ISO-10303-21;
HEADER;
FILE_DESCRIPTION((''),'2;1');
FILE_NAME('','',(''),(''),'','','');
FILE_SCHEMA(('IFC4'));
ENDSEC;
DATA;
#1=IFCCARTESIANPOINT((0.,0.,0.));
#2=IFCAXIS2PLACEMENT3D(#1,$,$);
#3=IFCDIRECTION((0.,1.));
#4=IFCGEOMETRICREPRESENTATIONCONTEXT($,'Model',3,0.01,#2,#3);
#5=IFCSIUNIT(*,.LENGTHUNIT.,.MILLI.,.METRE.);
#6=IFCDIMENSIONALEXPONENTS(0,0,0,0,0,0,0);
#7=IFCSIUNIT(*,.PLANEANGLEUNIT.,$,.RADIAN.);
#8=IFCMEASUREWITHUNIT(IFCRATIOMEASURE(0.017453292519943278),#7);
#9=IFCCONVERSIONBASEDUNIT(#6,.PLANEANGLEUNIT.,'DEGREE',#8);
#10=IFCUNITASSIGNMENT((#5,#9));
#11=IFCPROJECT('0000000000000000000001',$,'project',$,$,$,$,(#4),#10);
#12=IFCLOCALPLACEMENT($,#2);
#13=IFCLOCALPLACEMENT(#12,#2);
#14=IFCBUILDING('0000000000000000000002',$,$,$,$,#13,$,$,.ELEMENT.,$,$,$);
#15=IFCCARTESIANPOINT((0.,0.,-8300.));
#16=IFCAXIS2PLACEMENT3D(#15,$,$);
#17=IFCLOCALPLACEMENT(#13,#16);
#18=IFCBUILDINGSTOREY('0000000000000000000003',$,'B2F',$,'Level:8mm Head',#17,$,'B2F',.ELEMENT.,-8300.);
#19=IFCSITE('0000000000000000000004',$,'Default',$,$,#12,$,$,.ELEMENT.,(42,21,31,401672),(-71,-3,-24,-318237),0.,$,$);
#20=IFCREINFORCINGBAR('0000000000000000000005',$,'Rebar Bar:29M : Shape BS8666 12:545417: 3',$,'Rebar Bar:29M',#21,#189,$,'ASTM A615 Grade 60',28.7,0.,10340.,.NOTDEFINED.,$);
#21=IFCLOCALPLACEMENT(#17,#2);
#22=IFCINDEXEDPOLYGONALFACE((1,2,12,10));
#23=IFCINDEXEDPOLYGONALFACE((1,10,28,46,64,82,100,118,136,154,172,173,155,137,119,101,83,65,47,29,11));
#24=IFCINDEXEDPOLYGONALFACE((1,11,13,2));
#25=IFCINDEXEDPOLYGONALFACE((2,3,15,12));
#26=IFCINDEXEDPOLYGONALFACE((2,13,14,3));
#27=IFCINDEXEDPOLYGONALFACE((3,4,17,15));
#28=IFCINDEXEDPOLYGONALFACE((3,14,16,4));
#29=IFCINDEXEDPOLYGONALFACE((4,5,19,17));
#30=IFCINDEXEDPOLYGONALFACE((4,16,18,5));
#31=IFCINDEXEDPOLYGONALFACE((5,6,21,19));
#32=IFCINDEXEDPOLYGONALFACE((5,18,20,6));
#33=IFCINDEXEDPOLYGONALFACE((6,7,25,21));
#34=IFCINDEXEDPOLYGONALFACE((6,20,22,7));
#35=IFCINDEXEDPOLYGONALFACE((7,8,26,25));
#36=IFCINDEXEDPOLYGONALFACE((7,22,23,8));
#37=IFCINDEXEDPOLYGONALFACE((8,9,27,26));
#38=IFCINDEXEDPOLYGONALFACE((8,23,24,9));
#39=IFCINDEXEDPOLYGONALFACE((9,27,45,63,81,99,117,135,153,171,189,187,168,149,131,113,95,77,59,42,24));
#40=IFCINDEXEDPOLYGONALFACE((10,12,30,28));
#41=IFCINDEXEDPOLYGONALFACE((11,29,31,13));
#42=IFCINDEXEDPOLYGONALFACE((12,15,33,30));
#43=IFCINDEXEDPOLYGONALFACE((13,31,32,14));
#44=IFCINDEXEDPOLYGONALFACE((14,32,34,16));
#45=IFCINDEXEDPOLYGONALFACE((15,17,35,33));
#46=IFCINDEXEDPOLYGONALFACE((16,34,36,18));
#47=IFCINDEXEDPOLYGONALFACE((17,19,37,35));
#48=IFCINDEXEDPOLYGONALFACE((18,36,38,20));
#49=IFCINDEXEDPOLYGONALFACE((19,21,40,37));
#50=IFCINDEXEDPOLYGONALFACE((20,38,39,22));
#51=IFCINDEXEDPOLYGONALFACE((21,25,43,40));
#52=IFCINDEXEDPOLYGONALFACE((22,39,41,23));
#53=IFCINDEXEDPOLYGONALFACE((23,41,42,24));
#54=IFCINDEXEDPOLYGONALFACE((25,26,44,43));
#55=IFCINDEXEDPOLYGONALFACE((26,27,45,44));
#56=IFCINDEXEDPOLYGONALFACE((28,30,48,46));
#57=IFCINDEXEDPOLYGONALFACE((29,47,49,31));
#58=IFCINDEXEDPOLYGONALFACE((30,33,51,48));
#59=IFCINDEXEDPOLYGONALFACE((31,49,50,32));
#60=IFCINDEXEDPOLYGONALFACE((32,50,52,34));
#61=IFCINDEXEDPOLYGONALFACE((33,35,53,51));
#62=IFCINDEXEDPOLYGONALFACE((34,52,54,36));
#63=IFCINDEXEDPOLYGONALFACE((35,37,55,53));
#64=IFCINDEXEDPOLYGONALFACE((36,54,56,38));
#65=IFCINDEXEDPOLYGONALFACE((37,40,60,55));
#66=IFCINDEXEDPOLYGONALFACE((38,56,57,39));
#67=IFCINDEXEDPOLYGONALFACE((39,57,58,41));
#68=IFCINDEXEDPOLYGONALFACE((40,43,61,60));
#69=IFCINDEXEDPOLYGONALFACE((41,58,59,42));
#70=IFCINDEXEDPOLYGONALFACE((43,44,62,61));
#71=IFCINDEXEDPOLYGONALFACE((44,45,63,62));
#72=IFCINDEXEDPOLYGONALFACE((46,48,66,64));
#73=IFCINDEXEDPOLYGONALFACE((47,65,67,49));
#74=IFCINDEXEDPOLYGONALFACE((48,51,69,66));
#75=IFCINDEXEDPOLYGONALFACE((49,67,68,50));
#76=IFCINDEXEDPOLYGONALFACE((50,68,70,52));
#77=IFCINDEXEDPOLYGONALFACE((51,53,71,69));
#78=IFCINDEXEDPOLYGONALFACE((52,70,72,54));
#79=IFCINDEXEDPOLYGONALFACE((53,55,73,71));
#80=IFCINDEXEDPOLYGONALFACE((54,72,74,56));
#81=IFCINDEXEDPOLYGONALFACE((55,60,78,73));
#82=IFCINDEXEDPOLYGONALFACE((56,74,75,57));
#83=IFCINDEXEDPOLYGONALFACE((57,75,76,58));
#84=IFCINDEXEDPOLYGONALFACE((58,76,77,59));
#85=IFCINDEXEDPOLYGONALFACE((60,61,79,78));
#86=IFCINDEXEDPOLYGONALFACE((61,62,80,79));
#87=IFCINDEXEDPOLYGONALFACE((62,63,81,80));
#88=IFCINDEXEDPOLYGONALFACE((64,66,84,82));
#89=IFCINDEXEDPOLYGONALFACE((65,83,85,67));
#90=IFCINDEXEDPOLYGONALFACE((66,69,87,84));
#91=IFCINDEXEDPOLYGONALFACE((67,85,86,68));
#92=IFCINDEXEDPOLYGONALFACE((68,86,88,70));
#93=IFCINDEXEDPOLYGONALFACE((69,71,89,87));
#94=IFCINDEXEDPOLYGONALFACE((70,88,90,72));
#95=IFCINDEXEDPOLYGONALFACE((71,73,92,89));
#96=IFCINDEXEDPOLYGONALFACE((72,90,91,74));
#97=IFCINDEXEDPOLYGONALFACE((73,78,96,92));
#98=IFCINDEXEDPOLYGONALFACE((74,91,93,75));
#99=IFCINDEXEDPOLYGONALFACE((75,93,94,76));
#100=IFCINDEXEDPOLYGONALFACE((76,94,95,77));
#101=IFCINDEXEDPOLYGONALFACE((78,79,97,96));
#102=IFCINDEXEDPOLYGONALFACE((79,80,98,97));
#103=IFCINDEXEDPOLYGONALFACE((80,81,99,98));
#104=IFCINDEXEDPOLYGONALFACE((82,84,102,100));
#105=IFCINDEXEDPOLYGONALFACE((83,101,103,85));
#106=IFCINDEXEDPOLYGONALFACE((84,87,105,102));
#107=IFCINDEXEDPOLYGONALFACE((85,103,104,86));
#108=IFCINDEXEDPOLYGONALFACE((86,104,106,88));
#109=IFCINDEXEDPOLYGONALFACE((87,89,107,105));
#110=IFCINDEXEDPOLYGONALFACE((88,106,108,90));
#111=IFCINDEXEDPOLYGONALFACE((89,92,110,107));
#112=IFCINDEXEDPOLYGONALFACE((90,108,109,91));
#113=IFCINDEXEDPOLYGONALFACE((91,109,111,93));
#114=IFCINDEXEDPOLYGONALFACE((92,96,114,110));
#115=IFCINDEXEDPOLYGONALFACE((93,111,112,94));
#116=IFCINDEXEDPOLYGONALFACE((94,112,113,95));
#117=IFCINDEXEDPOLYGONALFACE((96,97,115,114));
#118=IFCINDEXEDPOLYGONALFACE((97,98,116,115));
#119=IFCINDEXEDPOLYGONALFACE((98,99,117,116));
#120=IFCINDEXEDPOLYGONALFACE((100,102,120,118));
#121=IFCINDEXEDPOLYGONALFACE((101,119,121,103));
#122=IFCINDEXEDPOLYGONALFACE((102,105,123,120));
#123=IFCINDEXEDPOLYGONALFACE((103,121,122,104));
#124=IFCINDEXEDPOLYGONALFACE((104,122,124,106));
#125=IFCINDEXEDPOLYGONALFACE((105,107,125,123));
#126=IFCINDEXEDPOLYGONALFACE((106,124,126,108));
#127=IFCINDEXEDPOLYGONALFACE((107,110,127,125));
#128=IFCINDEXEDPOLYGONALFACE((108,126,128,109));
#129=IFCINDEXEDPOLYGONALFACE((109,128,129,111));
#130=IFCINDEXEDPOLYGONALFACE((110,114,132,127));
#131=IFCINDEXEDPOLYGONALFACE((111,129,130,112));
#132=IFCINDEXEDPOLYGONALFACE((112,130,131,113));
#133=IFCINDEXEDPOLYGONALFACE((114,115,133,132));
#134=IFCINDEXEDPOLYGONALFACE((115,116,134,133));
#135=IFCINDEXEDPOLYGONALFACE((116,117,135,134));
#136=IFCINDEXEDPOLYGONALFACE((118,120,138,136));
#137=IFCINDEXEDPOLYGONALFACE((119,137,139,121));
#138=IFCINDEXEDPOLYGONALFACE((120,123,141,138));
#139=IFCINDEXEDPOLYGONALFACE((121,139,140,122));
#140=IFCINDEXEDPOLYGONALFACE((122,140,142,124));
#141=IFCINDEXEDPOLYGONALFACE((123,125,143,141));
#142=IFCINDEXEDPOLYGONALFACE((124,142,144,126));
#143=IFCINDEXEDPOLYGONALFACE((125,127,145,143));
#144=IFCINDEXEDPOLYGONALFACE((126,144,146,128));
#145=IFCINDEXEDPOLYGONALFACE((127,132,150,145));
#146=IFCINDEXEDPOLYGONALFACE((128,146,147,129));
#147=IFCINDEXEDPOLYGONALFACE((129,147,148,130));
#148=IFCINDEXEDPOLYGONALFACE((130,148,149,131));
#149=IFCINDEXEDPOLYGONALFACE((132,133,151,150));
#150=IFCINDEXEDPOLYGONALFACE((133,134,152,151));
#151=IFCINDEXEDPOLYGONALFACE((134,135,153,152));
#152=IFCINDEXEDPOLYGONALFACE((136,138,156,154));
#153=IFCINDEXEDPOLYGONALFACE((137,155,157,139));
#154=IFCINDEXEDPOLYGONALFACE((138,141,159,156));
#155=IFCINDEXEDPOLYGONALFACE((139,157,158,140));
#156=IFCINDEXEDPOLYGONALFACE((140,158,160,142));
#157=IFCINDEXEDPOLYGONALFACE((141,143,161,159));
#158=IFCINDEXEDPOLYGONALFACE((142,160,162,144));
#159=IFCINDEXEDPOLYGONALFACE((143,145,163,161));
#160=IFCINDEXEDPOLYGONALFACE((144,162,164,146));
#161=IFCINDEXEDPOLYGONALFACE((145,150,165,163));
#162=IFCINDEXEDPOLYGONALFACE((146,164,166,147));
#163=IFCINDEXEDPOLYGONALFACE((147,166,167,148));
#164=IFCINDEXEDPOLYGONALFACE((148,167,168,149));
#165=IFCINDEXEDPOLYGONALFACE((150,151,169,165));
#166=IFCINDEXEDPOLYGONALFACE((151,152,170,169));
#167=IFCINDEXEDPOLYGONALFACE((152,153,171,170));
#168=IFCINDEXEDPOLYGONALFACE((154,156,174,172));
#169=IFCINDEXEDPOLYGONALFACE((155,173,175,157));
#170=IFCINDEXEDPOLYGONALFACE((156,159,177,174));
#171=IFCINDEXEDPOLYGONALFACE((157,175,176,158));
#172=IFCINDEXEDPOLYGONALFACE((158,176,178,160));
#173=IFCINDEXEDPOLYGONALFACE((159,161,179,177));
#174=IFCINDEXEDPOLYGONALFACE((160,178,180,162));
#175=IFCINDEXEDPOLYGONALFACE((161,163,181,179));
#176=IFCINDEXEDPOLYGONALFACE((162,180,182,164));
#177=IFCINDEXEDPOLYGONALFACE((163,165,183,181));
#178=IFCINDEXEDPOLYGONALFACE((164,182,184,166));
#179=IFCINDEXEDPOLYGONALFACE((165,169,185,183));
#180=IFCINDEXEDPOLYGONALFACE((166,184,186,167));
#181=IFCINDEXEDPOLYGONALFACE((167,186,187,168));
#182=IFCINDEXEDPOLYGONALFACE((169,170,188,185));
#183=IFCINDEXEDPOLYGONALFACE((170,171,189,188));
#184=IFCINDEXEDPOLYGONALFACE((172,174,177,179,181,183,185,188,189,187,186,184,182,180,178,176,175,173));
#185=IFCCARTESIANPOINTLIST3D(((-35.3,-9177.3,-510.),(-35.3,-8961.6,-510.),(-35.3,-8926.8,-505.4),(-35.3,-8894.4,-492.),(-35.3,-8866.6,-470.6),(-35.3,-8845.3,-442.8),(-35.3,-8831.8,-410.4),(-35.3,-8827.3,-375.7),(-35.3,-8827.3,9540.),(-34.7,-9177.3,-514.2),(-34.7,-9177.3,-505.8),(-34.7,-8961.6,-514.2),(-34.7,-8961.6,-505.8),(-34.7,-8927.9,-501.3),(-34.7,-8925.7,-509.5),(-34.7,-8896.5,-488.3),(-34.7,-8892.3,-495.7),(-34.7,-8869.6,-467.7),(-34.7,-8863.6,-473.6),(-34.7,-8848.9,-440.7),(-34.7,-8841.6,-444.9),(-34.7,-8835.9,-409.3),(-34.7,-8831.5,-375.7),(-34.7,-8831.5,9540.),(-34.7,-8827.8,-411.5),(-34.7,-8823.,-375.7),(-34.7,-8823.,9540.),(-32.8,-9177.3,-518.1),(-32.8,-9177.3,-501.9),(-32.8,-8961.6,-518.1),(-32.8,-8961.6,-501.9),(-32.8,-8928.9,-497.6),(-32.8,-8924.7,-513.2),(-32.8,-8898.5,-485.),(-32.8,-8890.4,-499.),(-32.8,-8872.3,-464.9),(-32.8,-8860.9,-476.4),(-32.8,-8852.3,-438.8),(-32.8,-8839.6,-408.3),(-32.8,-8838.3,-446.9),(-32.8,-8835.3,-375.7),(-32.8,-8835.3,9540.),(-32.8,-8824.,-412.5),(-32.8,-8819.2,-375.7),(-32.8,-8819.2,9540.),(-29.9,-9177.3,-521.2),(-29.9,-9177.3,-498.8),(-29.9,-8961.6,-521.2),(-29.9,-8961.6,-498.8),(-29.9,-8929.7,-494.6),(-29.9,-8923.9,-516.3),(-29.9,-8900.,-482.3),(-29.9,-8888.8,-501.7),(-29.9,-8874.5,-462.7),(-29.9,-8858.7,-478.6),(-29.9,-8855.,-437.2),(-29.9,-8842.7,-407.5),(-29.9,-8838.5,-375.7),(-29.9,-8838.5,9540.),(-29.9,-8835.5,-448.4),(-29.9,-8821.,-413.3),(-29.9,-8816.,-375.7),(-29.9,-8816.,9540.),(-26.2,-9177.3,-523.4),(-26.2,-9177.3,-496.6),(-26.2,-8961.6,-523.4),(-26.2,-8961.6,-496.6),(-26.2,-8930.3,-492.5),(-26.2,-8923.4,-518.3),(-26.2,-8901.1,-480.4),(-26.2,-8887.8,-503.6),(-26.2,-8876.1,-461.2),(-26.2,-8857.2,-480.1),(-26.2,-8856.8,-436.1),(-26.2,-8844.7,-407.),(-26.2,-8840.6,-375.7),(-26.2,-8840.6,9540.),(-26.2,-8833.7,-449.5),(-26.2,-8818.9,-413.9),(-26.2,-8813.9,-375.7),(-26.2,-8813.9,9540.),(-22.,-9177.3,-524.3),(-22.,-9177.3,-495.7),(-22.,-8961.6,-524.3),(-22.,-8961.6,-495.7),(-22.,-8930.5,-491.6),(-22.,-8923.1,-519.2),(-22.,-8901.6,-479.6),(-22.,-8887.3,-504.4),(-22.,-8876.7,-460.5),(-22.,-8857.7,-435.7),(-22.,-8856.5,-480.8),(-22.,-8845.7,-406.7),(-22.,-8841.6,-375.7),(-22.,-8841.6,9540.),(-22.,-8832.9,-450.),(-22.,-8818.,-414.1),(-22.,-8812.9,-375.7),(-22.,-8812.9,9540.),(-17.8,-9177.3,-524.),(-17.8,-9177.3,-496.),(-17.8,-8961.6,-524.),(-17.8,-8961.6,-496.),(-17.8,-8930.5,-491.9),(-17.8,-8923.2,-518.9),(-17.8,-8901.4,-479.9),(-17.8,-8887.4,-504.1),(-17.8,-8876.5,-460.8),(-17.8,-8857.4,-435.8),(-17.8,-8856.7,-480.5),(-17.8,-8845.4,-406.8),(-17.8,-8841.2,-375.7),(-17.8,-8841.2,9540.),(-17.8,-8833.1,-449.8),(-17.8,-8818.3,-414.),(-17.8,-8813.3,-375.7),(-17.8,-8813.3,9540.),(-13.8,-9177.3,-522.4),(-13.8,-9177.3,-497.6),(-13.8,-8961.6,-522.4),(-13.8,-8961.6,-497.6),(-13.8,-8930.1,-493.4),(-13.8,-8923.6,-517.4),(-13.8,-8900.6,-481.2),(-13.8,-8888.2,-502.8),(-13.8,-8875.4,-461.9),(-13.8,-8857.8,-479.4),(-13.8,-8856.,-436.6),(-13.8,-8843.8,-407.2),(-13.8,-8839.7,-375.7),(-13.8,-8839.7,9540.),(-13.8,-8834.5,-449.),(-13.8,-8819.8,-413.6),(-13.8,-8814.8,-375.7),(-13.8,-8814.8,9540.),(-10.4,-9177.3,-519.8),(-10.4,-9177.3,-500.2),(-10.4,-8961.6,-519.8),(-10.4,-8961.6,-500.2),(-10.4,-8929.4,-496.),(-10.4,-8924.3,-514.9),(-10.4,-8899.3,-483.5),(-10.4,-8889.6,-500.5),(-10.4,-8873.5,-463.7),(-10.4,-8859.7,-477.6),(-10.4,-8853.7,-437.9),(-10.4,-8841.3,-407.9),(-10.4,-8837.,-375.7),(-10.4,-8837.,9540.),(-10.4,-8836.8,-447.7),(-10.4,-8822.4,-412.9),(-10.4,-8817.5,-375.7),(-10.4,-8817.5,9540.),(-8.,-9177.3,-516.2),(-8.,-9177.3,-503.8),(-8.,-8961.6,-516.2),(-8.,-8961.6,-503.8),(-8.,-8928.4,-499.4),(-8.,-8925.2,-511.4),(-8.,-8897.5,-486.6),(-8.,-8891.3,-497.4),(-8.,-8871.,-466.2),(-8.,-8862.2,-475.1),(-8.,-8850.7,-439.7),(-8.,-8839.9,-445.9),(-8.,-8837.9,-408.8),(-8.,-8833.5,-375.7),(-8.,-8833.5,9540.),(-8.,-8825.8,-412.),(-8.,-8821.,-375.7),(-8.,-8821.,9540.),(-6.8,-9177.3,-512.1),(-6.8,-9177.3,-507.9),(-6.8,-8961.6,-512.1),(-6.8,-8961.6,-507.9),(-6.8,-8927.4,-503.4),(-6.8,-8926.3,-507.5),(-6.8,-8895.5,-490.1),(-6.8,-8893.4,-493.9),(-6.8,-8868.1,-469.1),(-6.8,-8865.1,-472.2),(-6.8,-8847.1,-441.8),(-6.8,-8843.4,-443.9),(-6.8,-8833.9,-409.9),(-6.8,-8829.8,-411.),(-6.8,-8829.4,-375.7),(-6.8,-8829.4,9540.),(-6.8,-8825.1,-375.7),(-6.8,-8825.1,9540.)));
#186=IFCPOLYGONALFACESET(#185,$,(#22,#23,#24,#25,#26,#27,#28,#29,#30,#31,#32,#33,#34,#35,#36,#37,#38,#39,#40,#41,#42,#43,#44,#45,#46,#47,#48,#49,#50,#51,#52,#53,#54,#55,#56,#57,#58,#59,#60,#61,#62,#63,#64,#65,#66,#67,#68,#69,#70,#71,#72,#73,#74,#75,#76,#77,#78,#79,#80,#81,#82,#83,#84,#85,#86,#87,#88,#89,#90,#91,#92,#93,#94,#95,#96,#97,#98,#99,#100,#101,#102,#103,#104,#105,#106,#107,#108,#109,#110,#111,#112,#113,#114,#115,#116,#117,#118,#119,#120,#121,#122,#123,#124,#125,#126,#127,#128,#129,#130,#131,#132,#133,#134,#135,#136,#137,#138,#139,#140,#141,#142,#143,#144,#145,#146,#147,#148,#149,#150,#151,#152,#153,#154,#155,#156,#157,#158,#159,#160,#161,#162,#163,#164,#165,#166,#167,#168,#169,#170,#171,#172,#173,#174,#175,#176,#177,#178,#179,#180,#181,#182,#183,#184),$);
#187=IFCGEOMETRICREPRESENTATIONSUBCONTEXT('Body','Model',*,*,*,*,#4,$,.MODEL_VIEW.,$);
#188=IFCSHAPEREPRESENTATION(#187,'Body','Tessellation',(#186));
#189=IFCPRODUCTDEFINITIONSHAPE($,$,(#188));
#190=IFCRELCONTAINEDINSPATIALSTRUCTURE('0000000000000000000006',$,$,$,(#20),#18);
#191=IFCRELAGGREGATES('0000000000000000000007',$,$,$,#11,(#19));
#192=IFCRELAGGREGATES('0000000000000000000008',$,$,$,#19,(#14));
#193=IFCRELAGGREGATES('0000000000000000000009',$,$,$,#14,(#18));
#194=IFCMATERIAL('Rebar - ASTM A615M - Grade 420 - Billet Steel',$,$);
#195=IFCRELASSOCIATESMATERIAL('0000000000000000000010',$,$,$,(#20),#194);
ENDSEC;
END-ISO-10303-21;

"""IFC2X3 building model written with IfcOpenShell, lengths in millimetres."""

from ifc_helpers import new_model, entity, si_unit, converted_unit, direction, frame, origin, place, context, subcontext, project, spatial, material, element, save


model = new_model("IFC2X3")

# Units and contexts
model_context = context("Model", 3, precision=0.01, world=origin(), true_north=direction((0.0, 1.0)))
body_context = subcontext(model_context, "Body", "Model", "MODEL_VIEW")
ifc_project = project(units=[si_unit("LENGTHUNIT", "METRE", prefix="MILLI"), converted_unit("PLANEANGLEUNIT", "DEGREE", entity("IfcRatioMeasure", 0.017453292519943278), si_unit("PLANEANGLEUNIT", "RADIAN"), dimensions=[0, 0, 0, 0, 0, 0, 0])], contexts=[model_context])

# Site, building, storey
site_placement = place(None, origin())
site = spatial("IfcSite", under=ifc_project, at=site_placement, Name="Default", CompositionType="ELEMENT", RefLatitude=(42, 21, 31, 401672), RefLongitude=(-71, -3, -24, -318237), RefElevation=0.0)
building_placement = place(site_placement, origin())
building = spatial("IfcBuilding", under=site, at=building_placement, CompositionType="ELEMENT")
storey_placement = place(building_placement, frame((0.0, 0.0, -8300.0)))
storey = spatial("IfcBuildingStorey", under=building, at=storey_placement, Name="B2F", ObjectType="Level:8mm Head", LongName="B2F", CompositionType="ELEMENT", Elevation=-8300.0)

# Reinforcing bar
ifc_material_1 = material(Name="Rebar - ASTM A615M - Grade 420 - Billet Steel")
reinforcing_bar_1_placement = place(storey_placement, origin())
element("IfcReinforcingBar", 1, at=reinforcing_bar_1_placement, inside=storey, material=ifc_material_1, Name="Rebar Bar:29M : Shape BS8666 12:545417: 3", SteelGrade="ASTM A615 Grade 60", ObjectType="Rebar Bar:29M", BarLength=10340.0, BarRole="NOTDEFINED", CrossSectionArea=0.0, NominalDiameter=28.7, context=body_context, shape_type="AdvancedSweptSolid", body=[
    entity("IfcSweptDiskSolid", entity("IfcCompositeCurve", [entity("IfcCompositeCurveSegment", "CONTINUOUS", True, entity("IfcPolyline", [entity("IfcCartesianPoint", [-21.0, -8827.3, 9540.0]), entity("IfcCartesianPoint", [-21.0, -8827.3, -375.7])])), entity("IfcCompositeCurveSegment", "CONTINUOUS", True, entity("IfcTrimmedCurve", entity("IfcCircle", entity("IfcAxis2Placement3D", entity("IfcCartesianPoint", [-21.0, -8961.6, -375.7]), entity("IfcDirection", [-1.0, 0.0, 0.0]), entity("IfcDirection", [0.0, 0.0, -1.0])), 134.3), [entity("IfcParameterValue", 270.0)], [entity("IfcParameterValue", 360.0)], True, "PARAMETER")), entity("IfcCompositeCurveSegment", "CONTINUOUS", True, entity("IfcPolyline", [entity("IfcCartesianPoint", [-21.0, -8961.6, -510.0]), entity("IfcCartesianPoint", [-21.0, -9177.3, -510.0])]))], False), 14.3, None, 0.0, 92.0),
])

save(model, "model.ifc")
